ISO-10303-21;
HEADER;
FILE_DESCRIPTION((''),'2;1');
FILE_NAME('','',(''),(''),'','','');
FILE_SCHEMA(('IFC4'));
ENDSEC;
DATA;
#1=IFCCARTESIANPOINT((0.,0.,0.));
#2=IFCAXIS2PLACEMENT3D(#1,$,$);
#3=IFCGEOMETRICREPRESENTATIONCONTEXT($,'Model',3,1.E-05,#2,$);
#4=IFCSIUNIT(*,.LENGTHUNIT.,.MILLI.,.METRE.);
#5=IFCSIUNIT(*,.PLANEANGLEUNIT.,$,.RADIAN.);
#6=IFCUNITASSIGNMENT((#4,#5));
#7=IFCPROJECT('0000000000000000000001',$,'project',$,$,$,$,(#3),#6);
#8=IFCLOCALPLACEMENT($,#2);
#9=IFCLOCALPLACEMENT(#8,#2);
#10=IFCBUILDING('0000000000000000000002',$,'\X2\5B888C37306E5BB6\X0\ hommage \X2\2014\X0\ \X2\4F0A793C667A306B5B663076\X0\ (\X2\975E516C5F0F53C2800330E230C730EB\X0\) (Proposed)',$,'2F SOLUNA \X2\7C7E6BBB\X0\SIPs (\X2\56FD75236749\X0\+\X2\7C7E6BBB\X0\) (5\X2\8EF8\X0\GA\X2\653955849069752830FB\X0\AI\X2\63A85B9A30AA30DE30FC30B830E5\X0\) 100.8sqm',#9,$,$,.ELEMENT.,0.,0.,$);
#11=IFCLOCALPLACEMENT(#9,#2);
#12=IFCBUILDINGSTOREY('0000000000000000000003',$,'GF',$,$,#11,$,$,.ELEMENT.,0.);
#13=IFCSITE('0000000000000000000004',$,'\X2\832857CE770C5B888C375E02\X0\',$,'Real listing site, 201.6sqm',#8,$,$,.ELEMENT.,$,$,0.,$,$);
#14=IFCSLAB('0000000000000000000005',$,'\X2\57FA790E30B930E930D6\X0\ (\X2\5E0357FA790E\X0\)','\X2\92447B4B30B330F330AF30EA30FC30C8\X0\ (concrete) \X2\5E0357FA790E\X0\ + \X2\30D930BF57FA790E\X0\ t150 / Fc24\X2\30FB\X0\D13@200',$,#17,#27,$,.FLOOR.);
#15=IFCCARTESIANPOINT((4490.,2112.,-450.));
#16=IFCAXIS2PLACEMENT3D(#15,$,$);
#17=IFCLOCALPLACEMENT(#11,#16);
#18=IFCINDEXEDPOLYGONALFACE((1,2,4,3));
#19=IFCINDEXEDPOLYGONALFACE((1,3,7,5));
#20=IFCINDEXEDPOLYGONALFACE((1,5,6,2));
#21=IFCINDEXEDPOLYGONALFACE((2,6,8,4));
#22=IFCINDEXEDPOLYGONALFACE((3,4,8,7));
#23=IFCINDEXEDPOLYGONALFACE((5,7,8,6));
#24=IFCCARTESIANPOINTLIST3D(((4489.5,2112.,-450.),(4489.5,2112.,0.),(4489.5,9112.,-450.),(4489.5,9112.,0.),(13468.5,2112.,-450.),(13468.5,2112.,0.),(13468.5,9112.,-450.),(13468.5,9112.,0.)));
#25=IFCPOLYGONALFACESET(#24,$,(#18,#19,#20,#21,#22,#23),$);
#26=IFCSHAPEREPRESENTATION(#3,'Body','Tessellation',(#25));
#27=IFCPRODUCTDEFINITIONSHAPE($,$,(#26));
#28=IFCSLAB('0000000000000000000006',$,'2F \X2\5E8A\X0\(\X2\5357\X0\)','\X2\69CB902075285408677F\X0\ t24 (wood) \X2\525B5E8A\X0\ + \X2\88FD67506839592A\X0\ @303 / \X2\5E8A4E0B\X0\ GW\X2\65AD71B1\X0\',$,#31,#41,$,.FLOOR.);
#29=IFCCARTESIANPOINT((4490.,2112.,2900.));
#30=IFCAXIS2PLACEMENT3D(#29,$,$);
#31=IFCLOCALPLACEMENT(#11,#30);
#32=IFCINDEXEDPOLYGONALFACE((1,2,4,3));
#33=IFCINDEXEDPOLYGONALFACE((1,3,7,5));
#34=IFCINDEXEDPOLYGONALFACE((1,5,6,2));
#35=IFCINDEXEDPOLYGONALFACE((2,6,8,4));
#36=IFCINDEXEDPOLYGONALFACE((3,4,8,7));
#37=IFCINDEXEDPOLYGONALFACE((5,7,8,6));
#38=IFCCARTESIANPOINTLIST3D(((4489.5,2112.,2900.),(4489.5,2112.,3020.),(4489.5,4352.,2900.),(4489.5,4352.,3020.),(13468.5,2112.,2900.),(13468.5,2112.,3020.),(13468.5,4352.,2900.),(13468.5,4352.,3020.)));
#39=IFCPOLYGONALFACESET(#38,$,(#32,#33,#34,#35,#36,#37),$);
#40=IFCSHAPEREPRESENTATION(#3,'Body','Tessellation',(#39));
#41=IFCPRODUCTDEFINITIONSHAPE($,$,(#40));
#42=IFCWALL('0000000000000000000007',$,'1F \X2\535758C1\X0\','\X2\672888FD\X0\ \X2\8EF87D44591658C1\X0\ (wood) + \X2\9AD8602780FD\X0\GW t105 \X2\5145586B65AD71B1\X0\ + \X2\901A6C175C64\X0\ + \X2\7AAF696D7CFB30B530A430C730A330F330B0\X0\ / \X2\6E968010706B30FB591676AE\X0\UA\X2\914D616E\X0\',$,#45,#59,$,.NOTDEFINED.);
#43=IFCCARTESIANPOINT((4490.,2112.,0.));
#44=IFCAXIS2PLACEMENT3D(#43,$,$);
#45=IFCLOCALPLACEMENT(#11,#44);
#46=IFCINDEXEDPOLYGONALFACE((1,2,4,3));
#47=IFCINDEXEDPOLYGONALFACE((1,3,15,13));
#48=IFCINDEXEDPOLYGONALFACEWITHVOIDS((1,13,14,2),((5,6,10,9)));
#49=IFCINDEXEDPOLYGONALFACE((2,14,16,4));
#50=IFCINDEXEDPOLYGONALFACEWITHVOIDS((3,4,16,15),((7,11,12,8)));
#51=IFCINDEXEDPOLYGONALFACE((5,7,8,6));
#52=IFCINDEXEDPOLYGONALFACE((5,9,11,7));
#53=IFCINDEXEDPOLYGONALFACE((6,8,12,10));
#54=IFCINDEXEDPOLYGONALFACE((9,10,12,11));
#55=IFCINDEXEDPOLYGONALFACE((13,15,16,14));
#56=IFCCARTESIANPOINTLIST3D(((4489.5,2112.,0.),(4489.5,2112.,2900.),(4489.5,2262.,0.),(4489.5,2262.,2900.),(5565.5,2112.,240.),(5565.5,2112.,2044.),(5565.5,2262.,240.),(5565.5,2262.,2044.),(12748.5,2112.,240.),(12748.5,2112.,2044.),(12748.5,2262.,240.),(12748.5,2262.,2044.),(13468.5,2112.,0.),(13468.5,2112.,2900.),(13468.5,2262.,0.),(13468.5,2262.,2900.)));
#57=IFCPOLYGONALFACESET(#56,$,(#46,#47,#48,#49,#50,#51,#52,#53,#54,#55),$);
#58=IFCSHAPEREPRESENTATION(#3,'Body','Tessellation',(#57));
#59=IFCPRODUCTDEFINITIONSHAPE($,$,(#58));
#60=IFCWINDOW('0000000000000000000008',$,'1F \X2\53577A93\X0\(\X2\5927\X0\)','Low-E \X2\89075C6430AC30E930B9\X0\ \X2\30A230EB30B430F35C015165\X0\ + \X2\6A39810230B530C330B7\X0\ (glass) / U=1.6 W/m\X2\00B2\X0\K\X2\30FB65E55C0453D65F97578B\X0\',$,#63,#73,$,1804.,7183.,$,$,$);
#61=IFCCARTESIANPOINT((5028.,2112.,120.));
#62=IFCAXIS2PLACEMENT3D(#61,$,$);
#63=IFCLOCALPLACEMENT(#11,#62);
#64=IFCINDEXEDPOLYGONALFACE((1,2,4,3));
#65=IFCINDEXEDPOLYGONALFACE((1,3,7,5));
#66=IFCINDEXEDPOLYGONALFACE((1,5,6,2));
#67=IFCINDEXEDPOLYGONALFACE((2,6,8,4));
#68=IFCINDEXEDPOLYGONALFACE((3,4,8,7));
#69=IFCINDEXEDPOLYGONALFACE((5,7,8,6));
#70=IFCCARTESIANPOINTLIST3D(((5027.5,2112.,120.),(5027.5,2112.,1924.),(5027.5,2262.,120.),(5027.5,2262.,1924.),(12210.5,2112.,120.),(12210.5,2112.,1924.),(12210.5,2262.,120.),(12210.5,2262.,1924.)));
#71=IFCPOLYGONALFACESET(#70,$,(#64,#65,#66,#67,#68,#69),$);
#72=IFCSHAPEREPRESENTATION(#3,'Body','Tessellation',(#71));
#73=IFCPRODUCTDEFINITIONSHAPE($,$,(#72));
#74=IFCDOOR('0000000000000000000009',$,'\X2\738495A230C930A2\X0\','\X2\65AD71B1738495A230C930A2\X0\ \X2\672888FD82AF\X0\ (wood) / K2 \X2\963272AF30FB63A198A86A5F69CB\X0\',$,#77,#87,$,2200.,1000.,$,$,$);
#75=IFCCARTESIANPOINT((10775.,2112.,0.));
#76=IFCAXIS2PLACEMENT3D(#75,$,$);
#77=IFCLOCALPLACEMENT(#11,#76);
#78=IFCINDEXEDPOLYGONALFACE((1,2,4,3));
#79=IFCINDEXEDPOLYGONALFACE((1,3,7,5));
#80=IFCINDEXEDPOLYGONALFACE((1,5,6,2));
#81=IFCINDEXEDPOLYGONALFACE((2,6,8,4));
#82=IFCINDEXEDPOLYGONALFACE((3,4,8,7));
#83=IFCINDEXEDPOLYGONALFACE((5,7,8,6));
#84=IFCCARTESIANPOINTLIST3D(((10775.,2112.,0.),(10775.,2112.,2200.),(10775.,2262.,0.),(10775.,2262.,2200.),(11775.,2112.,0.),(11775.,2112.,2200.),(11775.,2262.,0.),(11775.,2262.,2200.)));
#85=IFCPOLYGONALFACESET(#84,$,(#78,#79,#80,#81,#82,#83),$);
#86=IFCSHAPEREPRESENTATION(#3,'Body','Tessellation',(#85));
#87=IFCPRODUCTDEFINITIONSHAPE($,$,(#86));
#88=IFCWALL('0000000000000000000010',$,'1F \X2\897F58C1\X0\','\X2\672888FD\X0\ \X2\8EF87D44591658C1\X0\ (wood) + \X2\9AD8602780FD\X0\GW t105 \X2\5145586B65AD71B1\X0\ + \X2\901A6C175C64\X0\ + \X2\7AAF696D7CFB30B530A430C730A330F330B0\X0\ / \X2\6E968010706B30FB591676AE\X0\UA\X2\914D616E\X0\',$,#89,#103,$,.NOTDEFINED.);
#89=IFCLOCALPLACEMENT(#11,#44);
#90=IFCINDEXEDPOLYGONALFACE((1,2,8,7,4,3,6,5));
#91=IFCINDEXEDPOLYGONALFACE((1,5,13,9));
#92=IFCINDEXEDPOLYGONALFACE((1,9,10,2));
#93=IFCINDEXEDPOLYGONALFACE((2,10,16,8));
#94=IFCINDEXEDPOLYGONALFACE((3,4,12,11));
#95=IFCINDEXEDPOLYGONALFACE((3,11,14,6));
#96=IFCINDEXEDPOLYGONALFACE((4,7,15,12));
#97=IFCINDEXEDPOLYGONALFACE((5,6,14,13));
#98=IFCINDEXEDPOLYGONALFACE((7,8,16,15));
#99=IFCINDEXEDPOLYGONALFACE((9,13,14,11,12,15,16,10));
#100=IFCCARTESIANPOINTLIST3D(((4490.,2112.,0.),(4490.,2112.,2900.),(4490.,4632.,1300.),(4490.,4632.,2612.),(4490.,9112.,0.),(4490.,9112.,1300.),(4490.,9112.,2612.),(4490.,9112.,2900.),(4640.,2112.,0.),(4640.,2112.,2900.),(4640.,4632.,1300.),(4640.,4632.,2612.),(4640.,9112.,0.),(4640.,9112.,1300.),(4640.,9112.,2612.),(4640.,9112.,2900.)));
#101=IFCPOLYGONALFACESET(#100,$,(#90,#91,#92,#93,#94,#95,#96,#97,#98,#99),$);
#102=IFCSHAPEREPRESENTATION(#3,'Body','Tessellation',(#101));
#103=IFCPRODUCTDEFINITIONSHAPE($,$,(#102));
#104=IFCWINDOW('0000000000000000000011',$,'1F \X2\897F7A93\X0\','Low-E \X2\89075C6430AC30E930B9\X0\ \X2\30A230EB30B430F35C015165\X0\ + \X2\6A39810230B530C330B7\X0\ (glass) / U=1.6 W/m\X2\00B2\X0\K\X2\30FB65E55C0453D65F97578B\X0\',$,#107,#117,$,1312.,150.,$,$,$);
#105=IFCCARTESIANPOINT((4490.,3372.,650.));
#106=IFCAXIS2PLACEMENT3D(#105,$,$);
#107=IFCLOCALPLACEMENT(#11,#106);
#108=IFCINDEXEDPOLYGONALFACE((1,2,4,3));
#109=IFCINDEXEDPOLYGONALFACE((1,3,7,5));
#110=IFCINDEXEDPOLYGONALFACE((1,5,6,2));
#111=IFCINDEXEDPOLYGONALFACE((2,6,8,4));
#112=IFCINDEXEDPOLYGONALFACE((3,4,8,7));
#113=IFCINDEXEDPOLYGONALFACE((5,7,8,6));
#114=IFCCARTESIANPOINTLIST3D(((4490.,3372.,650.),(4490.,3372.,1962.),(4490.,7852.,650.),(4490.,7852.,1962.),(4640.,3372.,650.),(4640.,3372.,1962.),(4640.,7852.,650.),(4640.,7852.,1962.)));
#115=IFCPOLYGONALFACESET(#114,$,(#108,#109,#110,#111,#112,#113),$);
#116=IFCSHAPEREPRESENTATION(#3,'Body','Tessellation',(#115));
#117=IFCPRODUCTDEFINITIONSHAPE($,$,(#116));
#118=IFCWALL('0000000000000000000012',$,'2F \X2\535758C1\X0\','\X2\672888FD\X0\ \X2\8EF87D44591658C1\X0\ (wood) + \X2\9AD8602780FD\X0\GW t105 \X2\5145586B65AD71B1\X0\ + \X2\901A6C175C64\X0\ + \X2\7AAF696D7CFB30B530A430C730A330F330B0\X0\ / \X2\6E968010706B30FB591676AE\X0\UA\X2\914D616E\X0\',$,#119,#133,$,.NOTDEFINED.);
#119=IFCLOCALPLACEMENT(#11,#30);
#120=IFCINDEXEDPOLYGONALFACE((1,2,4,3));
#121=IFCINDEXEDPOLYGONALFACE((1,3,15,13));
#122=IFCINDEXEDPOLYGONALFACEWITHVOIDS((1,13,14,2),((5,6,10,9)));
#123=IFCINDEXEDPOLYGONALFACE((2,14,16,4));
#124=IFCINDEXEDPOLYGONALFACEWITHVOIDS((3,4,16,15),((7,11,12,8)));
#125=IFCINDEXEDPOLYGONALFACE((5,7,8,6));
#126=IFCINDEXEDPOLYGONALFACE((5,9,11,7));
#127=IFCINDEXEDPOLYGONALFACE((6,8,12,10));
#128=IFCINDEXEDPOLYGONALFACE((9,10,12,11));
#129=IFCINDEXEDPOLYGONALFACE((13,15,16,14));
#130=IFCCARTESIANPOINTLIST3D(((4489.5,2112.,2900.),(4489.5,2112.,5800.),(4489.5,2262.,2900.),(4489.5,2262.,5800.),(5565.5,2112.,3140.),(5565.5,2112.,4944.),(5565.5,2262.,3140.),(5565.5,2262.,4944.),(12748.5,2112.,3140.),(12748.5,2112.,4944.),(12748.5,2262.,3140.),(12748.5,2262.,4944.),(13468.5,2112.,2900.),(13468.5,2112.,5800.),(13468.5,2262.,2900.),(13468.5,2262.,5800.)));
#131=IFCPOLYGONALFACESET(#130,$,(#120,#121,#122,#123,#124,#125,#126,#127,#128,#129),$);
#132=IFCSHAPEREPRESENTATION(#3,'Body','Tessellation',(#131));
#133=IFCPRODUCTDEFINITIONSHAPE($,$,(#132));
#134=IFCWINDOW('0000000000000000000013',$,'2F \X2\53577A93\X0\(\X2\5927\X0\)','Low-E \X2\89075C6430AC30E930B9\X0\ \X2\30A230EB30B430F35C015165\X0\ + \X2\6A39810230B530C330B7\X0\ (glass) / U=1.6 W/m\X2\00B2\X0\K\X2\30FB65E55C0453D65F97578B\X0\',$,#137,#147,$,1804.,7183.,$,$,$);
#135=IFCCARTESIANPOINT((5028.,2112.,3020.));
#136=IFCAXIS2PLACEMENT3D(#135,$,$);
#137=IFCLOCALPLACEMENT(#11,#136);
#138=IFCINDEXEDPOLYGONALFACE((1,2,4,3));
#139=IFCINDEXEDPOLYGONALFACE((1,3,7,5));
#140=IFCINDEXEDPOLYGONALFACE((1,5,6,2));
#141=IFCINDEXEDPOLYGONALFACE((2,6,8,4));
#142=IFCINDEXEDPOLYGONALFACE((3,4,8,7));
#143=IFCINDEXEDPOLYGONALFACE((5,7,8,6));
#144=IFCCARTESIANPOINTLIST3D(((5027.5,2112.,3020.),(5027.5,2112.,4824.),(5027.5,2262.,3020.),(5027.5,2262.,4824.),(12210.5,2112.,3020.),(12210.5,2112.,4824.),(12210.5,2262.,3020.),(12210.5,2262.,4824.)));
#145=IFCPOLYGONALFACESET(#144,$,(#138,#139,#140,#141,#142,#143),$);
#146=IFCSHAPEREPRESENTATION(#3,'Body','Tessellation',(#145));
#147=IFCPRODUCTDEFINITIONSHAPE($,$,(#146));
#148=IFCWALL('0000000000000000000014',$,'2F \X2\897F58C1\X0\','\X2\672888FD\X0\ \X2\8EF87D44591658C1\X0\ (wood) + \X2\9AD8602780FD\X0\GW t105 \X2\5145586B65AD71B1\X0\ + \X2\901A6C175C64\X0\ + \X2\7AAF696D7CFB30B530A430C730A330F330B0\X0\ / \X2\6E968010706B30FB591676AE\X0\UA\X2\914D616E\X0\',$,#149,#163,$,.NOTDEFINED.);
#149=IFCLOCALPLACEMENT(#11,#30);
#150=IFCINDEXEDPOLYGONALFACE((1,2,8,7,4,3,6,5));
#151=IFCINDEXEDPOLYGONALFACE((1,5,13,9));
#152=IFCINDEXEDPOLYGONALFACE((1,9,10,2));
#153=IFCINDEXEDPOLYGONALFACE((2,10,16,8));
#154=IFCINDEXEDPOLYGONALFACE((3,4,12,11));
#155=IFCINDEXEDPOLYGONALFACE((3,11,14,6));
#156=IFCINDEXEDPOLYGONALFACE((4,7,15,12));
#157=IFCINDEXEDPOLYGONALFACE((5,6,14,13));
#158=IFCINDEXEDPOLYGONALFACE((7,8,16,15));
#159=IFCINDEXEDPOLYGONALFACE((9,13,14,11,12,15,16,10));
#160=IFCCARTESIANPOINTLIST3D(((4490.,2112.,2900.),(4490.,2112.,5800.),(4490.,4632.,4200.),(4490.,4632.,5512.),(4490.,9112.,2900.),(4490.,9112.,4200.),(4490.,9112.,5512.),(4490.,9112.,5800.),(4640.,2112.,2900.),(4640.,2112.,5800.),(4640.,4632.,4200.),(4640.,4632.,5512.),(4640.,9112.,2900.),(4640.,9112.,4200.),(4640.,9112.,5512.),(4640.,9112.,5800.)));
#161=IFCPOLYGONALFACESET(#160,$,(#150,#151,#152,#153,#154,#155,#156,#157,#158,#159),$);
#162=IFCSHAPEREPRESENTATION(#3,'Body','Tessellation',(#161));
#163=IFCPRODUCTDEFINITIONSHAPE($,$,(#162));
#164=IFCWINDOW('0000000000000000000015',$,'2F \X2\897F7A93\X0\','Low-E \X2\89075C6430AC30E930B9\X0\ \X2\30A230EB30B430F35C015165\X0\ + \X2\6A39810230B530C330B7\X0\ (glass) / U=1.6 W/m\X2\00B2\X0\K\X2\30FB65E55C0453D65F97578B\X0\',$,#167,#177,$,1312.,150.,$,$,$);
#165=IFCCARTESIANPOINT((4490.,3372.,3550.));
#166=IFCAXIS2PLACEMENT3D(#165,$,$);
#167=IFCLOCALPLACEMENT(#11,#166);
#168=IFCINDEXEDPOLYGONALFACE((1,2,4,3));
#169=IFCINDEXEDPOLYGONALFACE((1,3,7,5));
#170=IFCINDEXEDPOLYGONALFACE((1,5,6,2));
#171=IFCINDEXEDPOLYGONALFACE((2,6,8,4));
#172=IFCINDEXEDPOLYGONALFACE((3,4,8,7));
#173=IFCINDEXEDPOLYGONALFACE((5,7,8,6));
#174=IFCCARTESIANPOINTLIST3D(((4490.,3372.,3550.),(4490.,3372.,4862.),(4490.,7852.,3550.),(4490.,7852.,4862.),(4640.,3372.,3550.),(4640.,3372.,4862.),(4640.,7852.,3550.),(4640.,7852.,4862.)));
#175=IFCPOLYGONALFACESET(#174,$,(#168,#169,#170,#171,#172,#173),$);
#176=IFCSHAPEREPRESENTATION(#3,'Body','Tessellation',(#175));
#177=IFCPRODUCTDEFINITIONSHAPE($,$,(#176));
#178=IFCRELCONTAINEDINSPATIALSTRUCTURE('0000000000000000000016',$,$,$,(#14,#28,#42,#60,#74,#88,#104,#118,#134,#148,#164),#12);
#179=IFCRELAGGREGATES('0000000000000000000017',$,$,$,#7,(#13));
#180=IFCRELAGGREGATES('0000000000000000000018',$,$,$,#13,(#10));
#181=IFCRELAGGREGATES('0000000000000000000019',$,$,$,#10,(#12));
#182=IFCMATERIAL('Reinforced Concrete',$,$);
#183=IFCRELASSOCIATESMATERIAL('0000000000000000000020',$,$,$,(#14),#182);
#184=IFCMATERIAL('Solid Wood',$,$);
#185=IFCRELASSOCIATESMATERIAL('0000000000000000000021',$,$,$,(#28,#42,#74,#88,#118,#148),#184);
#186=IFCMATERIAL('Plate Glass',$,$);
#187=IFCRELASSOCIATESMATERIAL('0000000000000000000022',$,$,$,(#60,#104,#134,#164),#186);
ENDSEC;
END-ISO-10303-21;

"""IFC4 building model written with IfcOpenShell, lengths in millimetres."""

from ifc_helpers import new_model, si_unit, frame, frame_2d, origin, place, context, project, spatial, rectangle, extrude, material, element, fill, save


model = new_model("IFC4")

# Units and contexts
model_context = context("Model", 3, precision=1e-05, world=origin())
ifc_project = project(units=[si_unit("LENGTHUNIT", "METRE", prefix="MILLI"), si_unit("PLANEANGLEUNIT", "RADIAN")], contexts=[model_context])

# Site, building, storey
site_placement = place(None, origin())
site = spatial("IfcSite", under=ifc_project, at=site_placement, Name="茨城県守谷市", ObjectType="Real listing site, 201.6sqm", CompositionType="ELEMENT", RefElevation=0.0)
building_placement = place(site_placement, origin())
building = spatial("IfcBuilding", under=site, at=building_placement, Name="守谷の家 hommage — 伊礼智に学ぶ (非公式参考モデル) (Proposed)", ObjectType="2F SOLUNA 籾殻SIPs (国産杉+籾殻) (5軸GA改善適用・AI推定オマージュ) 100.8sqm", CompositionType="ELEMENT", ElevationOfRefHeight=0.0, ElevationOfTerrain=0.0)
storey_placement = place(building_placement, origin())
storey = spatial("IfcBuildingStorey", under=building, at=storey_placement, Name="GF", CompositionType="ELEMENT", Elevation=0.0)

# Slabs
ifc_material_1 = material(Name="Reinforced Concrete")
slab_1_placement = place(storey_placement, frame((4490.0, 2112.0, -450.0)))
element("IfcSlab", 1, at=slab_1_placement, inside=storey, material=ifc_material_1, Name="基礎スラブ (布基礎)", Description="鉄筋コンクリート (concrete) 布基礎 + ベタ基礎 t150 / Fc24・D13@200", PredefinedType="FLOOR", context=model_context, shape_type="SweptSolid", body=[
    extrude(rectangle(XDim=8979.0, YDim=7000.0, at=frame_2d((4489.0, 3500.0))), frame((4490.0, 2112.0, -450.0)), (0.0, 0.0, 1.0), 450.0),
])
ifc_material_2 = material(Name="Solid Wood")
slab_2_placement = place(storey_placement, frame((4490.0, 2112.0, 2900.0)))
element("IfcSlab", 2, at=slab_2_placement, inside=storey, material=ifc_material_2, Name="2F 床(南)", Description="構造用合板 t24 (wood) 剛床 + 製材根太 @303 / 床下 GW断熱", PredefinedType="FLOOR", context=model_context, shape_type="SweptSolid", body=[
    extrude(rectangle(XDim=8979.0, YDim=2240.0, at=frame_2d((4489.0, 1120.0))), frame((4490.0, 2112.0, 2900.0)), (0.0, 0.0, 1.0), 120.0),
])

# Wall, openings, window, door
wall_1_placement = place(storey_placement, frame((4490.0, 2112.0, 0.0)))
wall_1 = element("IfcWall", 3, at=wall_1_placement, inside=storey, material=ifc_material_2, Name="1F 南壁", Description="木製 軸組外壁 (wood) + 高性能GW t105 充填断熱 + 通気層 + 窯業系サイディング / 準耐火・外皮UA配慮", PredefinedType="NOTDEFINED", context=model_context, shape_type="SweptSolid", body=[
    extrude(rectangle(XDim=8979.0, YDim=150.0, at=frame_2d((4489.0, 75.0))), frame((4490.0, 2112.0, 0.0)), (0.0, 0.0, 1.0), 2900.0),
])
opening_1_placement = place(storey_placement, frame((5028.0, 2112.0, 120.0)))
opening_1 = element("IfcOpeningElement", 4, at=opening_1_placement, cuts=wall_1, PredefinedType="NOTDEFINED", context=model_context, shape_type="SweptSolid", body=[
    extrude(rectangle(XDim=7183.0, YDim=150.0, at=frame_2d((3591.0, 75.0))), frame((5028.0, 2112.0, 120.0)), (0.0, 0.0, 1.0), 1804.0),
])
opening_2_placement = place(storey_placement, frame((10775.0, 2112.0, 0.0)))
opening_2 = element("IfcOpeningElement", 5, at=opening_2_placement, cuts=wall_1, PredefinedType="NOTDEFINED", context=model_context, shape_type="SweptSolid", body=[
    extrude(rectangle(XDim=1000.0, YDim=150.0, at=frame_2d((500.0, 75.0))), frame((10775.0, 2112.0, 0.0)), (0.0, 0.0, 1.0), 2200.0),
])
ifc_material_3 = material(Name="Plate Glass")
window_1_placement = place(storey_placement, frame((5028.0, 2112.0, 120.0)))
window_1 = element("IfcWindow", 6, at=window_1_placement, inside=storey, material=ifc_material_3, Name="1F 南窓(大)", Description="Low-E 複層ガラス アルゴン封入 + 樹脂サッシ (glass) / U=1.6 W/m²K・日射取得型", OverallHeight=1804.0, OverallWidth=7183.0, context=model_context, shape_type="SweptSolid", body=[
    extrude(rectangle(XDim=7183.0, YDim=150.0, at=frame_2d((3591.0, 75.0))), frame((5028.0, 2112.0, 120.0)), (0.0, 0.0, 1.0), 1804.0),
])
fill(opening_1, window_1)
door_placement = place(storey_placement, frame((10775.0, 2112.0, 0.0)))
door = element("IfcDoor", 7, at=door_placement, inside=storey, material=ifc_material_2, Name="玄関ドア", Description="断熱玄関ドア 木製芯 (wood) / K2 防犯・採風機構", OverallHeight=2200.0, OverallWidth=1000.0, context=model_context, shape_type="SweptSolid", body=[
    extrude(rectangle(XDim=1000.0, YDim=150.0, at=frame_2d((500.0, 75.0))), frame((10775.0, 2112.0, 0.0)), (0.0, 0.0, 1.0), 2200.0),
])
fill(opening_2, door)

# Walls, openings, windows
wall_2_placement = place(storey_placement, frame((4490.0, 2112.0, 0.0)))
wall_2 = element("IfcWall", 8, at=wall_2_placement, inside=storey, material=ifc_material_2, Name="1F 西壁", Description="木製 軸組外壁 (wood) + 高性能GW t105 充填断熱 + 通気層 + 窯業系サイディング / 準耐火・外皮UA配慮", PredefinedType="NOTDEFINED", context=model_context, shape_type="SweptSolid", body=[
    extrude(rectangle(XDim=150.0, YDim=7000.0, at=frame_2d((75.0, 3500.0))), frame((4490.0, 2112.0, 0.0)), (0.0, 0.0, 1.0), 2900.0),
])
opening_3_placement = place(storey_placement, frame((4490.0, 3372.0, 650.0)))
opening_3 = element("IfcOpeningElement", 9, at=opening_3_placement, cuts=wall_2, PredefinedType="NOTDEFINED", context=model_context, shape_type="SweptSolid", body=[
    extrude(rectangle(XDim=150.0, YDim=4480.0, at=frame_2d((75.0, 2240.0))), frame((4490.0, 3372.0, 650.0)), (0.0, 0.0, 1.0), 1312.0),
])
window_2_placement = place(storey_placement, frame((4490.0, 3372.0, 650.0)))
window_2 = element("IfcWindow", 10, at=window_2_placement, inside=storey, material=ifc_material_3, Name="1F 西窓", Description="Low-E 複層ガラス アルゴン封入 + 樹脂サッシ (glass) / U=1.6 W/m²K・日射取得型", OverallHeight=1312.0, OverallWidth=150.0, context=model_context, shape_type="SweptSolid", body=[
    extrude(rectangle(XDim=150.0, YDim=4480.0, at=frame_2d((75.0, 2240.0))), frame((4490.0, 3372.0, 650.0)), (0.0, 0.0, 1.0), 1312.0),
])
fill(opening_3, window_2)
wall_3_placement = place(storey_placement, frame((4490.0, 2112.0, 2900.0)))
wall_3 = element("IfcWall", 11, at=wall_3_placement, inside=storey, material=ifc_material_2, Name="2F 南壁", Description="木製 軸組外壁 (wood) + 高性能GW t105 充填断熱 + 通気層 + 窯業系サイディング / 準耐火・外皮UA配慮", PredefinedType="NOTDEFINED", context=model_context, shape_type="SweptSolid", body=[
    extrude(rectangle(XDim=8979.0, YDim=150.0, at=frame_2d((4489.0, 75.0))), frame((4490.0, 2112.0, 2900.0)), (0.0, 0.0, 1.0), 2900.0),
])
opening_4_placement = place(storey_placement, frame((5028.0, 2112.0, 3020.0)))
opening_4 = element("IfcOpeningElement", 12, at=opening_4_placement, cuts=wall_3, PredefinedType="NOTDEFINED", context=model_context, shape_type="SweptSolid", body=[
    extrude(rectangle(XDim=7183.0, YDim=150.0, at=frame_2d((3591.0, 75.0))), frame((5028.0, 2112.0, 3020.0)), (0.0, 0.0, 1.0), 1804.0),
])
window_3_placement = place(storey_placement, frame((5028.0, 2112.0, 3020.0)))
window_3 = element("IfcWindow", 13, at=window_3_placement, inside=storey, material=ifc_material_3, Name="2F 南窓(大)", Description="Low-E 複層ガラス アルゴン封入 + 樹脂サッシ (glass) / U=1.6 W/m²K・日射取得型", OverallHeight=1804.0, OverallWidth=7183.0, context=model_context, shape_type="SweptSolid", body=[
    extrude(rectangle(XDim=7183.0, YDim=150.0, at=frame_2d((3591.0, 75.0))), frame((5028.0, 2112.0, 3020.0)), (0.0, 0.0, 1.0), 1804.0),
])
fill(opening_4, window_3)
wall_4_placement = place(storey_placement, frame((4490.0, 2112.0, 2900.0)))
wall_4 = element("IfcWall", 14, at=wall_4_placement, inside=storey, material=ifc_material_2, Name="2F 西壁", Description="木製 軸組外壁 (wood) + 高性能GW t105 充填断熱 + 通気層 + 窯業系サイディング / 準耐火・外皮UA配慮", PredefinedType="NOTDEFINED", context=model_context, shape_type="SweptSolid", body=[
    extrude(rectangle(XDim=150.0, YDim=7000.0, at=frame_2d((75.0, 3500.0))), frame((4490.0, 2112.0, 2900.0)), (0.0, 0.0, 1.0), 2900.0),
])
opening_5_placement = place(storey_placement, frame((4490.0, 3372.0, 3550.0)))
opening_5 = element("IfcOpeningElement", 15, at=opening_5_placement, cuts=wall_4, PredefinedType="NOTDEFINED", context=model_context, shape_type="SweptSolid", body=[
    extrude(rectangle(XDim=150.0, YDim=4480.0, at=frame_2d((75.0, 2240.0))), frame((4490.0, 3372.0, 3550.0)), (0.0, 0.0, 1.0), 1312.0),
])
window_4_placement = place(storey_placement, frame((4490.0, 3372.0, 3550.0)))
window_4 = element("IfcWindow", 16, at=window_4_placement, inside=storey, material=ifc_material_3, Name="2F 西窓", Description="Low-E 複層ガラス アルゴン封入 + 樹脂サッシ (glass) / U=1.6 W/m²K・日射取得型", OverallHeight=1312.0, OverallWidth=150.0, context=model_context, shape_type="SweptSolid", body=[
    extrude(rectangle(XDim=150.0, YDim=4480.0, at=frame_2d((75.0, 2240.0))), frame((4490.0, 3372.0, 3550.0)), (0.0, 0.0, 1.0), 1312.0),
])
fill(opening_5, window_4)

save(model, "model.ifc")
